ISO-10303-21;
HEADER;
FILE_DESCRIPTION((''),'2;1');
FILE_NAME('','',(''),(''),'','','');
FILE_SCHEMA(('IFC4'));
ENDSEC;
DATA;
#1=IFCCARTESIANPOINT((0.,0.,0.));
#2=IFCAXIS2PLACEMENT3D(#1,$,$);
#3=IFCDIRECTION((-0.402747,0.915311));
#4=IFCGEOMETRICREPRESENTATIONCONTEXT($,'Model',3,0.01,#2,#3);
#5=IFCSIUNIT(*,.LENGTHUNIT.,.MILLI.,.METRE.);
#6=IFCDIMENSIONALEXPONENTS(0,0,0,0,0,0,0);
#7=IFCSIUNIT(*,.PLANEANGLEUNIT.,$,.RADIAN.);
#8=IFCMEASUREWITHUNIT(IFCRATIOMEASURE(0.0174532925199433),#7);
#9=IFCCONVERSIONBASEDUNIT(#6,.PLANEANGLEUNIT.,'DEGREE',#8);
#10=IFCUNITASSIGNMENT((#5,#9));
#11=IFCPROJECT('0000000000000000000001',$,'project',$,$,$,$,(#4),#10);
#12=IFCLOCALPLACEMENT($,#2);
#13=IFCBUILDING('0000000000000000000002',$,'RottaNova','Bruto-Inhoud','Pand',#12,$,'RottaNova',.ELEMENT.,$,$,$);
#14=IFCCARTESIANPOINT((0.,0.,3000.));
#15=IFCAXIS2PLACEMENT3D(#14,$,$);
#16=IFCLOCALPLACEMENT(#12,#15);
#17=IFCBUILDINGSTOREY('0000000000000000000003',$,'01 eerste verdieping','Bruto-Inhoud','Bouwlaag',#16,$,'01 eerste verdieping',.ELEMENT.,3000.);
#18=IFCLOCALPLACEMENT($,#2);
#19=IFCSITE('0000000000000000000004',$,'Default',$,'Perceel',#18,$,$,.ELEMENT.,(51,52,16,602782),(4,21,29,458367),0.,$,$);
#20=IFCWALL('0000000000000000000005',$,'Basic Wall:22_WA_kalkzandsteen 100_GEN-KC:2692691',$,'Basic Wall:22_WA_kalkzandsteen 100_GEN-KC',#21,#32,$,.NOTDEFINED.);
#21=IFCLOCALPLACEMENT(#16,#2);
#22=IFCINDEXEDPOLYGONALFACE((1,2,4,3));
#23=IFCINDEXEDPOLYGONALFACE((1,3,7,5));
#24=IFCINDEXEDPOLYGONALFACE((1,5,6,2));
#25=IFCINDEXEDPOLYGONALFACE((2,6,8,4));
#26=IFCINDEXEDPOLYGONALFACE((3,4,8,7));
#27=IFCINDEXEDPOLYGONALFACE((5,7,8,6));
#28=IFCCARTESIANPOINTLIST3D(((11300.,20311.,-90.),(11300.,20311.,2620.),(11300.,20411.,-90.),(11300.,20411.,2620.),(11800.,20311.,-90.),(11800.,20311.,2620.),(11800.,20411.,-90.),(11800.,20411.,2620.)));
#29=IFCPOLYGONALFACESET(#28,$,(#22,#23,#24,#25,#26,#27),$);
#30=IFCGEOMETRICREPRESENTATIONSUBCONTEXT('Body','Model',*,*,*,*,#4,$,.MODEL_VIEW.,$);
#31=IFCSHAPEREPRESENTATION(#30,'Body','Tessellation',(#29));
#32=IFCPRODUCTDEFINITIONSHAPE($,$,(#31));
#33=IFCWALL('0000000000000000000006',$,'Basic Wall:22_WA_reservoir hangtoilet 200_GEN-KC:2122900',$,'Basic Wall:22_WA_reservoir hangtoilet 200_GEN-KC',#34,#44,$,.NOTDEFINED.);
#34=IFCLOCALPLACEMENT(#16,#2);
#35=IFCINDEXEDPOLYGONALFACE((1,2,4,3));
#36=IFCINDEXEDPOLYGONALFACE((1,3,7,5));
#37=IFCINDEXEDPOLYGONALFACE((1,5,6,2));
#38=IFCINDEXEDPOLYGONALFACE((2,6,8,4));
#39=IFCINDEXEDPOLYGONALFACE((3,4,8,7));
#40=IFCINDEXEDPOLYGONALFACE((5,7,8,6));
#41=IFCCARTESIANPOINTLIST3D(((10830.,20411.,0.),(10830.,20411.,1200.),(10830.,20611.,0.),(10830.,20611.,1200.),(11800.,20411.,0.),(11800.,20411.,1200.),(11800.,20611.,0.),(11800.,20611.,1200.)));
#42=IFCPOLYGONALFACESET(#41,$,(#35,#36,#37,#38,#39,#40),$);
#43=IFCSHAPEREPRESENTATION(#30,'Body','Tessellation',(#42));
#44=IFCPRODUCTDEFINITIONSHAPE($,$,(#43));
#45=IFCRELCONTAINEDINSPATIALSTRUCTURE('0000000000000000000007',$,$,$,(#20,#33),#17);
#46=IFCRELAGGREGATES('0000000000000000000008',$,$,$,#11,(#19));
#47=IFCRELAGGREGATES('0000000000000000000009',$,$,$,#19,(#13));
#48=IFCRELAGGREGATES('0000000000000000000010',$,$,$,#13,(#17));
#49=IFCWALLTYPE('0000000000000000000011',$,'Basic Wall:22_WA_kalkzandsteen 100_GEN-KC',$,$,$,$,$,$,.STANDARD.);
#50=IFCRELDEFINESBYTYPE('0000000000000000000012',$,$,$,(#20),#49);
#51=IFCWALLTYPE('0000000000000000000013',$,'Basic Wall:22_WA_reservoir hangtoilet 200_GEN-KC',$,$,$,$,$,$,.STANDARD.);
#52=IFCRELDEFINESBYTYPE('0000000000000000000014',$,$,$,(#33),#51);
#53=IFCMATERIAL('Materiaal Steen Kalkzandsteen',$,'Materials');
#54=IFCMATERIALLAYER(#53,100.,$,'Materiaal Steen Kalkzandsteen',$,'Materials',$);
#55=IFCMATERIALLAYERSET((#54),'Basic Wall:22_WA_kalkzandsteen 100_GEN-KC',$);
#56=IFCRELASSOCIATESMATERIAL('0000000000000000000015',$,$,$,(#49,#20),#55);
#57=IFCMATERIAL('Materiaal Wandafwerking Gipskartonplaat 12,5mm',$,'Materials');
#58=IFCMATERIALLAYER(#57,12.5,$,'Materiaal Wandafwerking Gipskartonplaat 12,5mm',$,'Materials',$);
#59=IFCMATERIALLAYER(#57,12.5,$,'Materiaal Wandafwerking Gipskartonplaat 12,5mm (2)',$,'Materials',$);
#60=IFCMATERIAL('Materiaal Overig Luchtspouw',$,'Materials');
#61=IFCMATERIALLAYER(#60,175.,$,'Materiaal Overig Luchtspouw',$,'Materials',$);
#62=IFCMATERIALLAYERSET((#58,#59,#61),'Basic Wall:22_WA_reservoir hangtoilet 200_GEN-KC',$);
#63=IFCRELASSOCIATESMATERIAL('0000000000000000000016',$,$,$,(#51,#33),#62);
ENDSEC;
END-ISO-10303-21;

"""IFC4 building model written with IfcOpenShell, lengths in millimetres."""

from ifc_helpers import new_model, entity, si_unit, converted_unit, direction, frame, frame_2d, origin, place, context, subcontext, project, spatial, rectangle, extrude, material, layer, layer_set, type_object, element, save


model = new_model("IFC4")

# Units and contexts
model_context = context("Model", 3, precision=0.01, world=origin(), true_north=direction((-0.402747, 0.915311)))
body_context = subcontext(model_context, "Body", "Model", "MODEL_VIEW")
ifc_project = project(units=[si_unit("LENGTHUNIT", "METRE", prefix="MILLI"), converted_unit("PLANEANGLEUNIT", "DEGREE", entity("IfcRatioMeasure", 0.0174532925199433), si_unit("PLANEANGLEUNIT", "RADIAN"), dimensions=[0, 0, 0, 0, 0, 0, 0])], contexts=[model_context])

# Site, building, storey
site_placement = place(None, origin())
site = spatial("IfcSite", under=ifc_project, at=site_placement, Name="Default", ObjectType="Perceel", CompositionType="ELEMENT", RefLatitude=(51, 52, 16, 602782), RefLongitude=(4, 21, 29, 458367), RefElevation=0.0)
building_placement = place(None, origin())
building = spatial("IfcBuilding", under=site, at=building_placement, Name="RottaNova", Description="Bruto-Inhoud", ObjectType="Pand", LongName="RottaNova", CompositionType="ELEMENT")
storey_placement = place(building_placement, frame((0.0, 0.0, 3000.0)))
storey = spatial("IfcBuildingStorey", under=building, at=storey_placement, Name="01 eerste verdieping", Description="Bruto-Inhoud", ObjectType="Bouwlaag", LongName="01 eerste verdieping", CompositionType="ELEMENT", Elevation=3000.0)

# Shared definitions
ifc_material_1 = material(Name="Materiaal Steen Kalkzandsteen", Category="Materials")

# Walls
ifc_layer_1 = layer(ifc_material_1, 100.0, Name="Materiaal Steen Kalkzandsteen", Category="Materials")
ifc_layer_set_1 = layer_set([ifc_layer_1], Name="Basic Wall:22_WA_kalkzandsteen 100_GEN-KC")
wall_type_1 = type_object("IfcWallType", Name="Basic Wall:22_WA_kalkzandsteen 100_GEN-KC", PredefinedType="STANDARD", material=ifc_layer_set_1)
wall_1_placement = place(storey_placement, frame((11300.0, 20361.0, -90.0)))
element("IfcWall", 1, at=wall_1_placement, inside=storey, type_object=wall_type_1, material=ifc_layer_set_1, Name="Basic Wall:22_WA_kalkzandsteen 100_GEN-KC:2692691", ObjectType="Basic Wall:22_WA_kalkzandsteen 100_GEN-KC", PredefinedType="NOTDEFINED", context=body_context, shape_type="SweptSolid", body=[
    extrude(rectangle(XDim=500.0, YDim=100.0, at=frame_2d((250.0, 0.0), x_axis=(-1.0, 0.0))), origin(), (0.0, 0.0, 1.0), 2710.0),
])
ifc_material_2 = material(Name="Materiaal Wandafwerking Gipskartonplaat 12,5mm", Category="Materials")
ifc_layer_2 = layer(ifc_material_2, 12.5, Name="Materiaal Wandafwerking Gipskartonplaat 12,5mm", Category="Materials")
ifc_layer_3 = layer(ifc_material_2, 12.5, Name="Materiaal Wandafwerking Gipskartonplaat 12,5mm (2)", Category="Materials")
ifc_material_3 = material(Name="Materiaal Overig Luchtspouw", Category="Materials")
ifc_layer_4 = layer(ifc_material_3, 175.0, Name="Materiaal Overig Luchtspouw", Category="Materials")
ifc_layer_set_2 = layer_set([ifc_layer_2, ifc_layer_3, ifc_layer_4], Name="Basic Wall:22_WA_reservoir hangtoilet 200_GEN-KC")
wall_type_2 = type_object("IfcWallType", Name="Basic Wall:22_WA_reservoir hangtoilet 200_GEN-KC", PredefinedType="STANDARD", material=ifc_layer_set_2)
wall_2_placement = place(storey_placement, frame((10830.0, 20511.0, 0.0)))
element("IfcWall", 2, at=wall_2_placement, inside=storey, type_object=wall_type_2, material=ifc_layer_set_2, Name="Basic Wall:22_WA_reservoir hangtoilet 200_GEN-KC:2122900", ObjectType="Basic Wall:22_WA_reservoir hangtoilet 200_GEN-KC", PredefinedType="NOTDEFINED", context=body_context, shape_type="SweptSolid", body=[
    extrude(rectangle(XDim=970.0, YDim=200.0, at=frame_2d((485.0, 0.0), x_axis=(-1.0, 0.0))), origin(), (0.0, 0.0, 1.0), 1200.0),
])

save(model, "model.ifc")
